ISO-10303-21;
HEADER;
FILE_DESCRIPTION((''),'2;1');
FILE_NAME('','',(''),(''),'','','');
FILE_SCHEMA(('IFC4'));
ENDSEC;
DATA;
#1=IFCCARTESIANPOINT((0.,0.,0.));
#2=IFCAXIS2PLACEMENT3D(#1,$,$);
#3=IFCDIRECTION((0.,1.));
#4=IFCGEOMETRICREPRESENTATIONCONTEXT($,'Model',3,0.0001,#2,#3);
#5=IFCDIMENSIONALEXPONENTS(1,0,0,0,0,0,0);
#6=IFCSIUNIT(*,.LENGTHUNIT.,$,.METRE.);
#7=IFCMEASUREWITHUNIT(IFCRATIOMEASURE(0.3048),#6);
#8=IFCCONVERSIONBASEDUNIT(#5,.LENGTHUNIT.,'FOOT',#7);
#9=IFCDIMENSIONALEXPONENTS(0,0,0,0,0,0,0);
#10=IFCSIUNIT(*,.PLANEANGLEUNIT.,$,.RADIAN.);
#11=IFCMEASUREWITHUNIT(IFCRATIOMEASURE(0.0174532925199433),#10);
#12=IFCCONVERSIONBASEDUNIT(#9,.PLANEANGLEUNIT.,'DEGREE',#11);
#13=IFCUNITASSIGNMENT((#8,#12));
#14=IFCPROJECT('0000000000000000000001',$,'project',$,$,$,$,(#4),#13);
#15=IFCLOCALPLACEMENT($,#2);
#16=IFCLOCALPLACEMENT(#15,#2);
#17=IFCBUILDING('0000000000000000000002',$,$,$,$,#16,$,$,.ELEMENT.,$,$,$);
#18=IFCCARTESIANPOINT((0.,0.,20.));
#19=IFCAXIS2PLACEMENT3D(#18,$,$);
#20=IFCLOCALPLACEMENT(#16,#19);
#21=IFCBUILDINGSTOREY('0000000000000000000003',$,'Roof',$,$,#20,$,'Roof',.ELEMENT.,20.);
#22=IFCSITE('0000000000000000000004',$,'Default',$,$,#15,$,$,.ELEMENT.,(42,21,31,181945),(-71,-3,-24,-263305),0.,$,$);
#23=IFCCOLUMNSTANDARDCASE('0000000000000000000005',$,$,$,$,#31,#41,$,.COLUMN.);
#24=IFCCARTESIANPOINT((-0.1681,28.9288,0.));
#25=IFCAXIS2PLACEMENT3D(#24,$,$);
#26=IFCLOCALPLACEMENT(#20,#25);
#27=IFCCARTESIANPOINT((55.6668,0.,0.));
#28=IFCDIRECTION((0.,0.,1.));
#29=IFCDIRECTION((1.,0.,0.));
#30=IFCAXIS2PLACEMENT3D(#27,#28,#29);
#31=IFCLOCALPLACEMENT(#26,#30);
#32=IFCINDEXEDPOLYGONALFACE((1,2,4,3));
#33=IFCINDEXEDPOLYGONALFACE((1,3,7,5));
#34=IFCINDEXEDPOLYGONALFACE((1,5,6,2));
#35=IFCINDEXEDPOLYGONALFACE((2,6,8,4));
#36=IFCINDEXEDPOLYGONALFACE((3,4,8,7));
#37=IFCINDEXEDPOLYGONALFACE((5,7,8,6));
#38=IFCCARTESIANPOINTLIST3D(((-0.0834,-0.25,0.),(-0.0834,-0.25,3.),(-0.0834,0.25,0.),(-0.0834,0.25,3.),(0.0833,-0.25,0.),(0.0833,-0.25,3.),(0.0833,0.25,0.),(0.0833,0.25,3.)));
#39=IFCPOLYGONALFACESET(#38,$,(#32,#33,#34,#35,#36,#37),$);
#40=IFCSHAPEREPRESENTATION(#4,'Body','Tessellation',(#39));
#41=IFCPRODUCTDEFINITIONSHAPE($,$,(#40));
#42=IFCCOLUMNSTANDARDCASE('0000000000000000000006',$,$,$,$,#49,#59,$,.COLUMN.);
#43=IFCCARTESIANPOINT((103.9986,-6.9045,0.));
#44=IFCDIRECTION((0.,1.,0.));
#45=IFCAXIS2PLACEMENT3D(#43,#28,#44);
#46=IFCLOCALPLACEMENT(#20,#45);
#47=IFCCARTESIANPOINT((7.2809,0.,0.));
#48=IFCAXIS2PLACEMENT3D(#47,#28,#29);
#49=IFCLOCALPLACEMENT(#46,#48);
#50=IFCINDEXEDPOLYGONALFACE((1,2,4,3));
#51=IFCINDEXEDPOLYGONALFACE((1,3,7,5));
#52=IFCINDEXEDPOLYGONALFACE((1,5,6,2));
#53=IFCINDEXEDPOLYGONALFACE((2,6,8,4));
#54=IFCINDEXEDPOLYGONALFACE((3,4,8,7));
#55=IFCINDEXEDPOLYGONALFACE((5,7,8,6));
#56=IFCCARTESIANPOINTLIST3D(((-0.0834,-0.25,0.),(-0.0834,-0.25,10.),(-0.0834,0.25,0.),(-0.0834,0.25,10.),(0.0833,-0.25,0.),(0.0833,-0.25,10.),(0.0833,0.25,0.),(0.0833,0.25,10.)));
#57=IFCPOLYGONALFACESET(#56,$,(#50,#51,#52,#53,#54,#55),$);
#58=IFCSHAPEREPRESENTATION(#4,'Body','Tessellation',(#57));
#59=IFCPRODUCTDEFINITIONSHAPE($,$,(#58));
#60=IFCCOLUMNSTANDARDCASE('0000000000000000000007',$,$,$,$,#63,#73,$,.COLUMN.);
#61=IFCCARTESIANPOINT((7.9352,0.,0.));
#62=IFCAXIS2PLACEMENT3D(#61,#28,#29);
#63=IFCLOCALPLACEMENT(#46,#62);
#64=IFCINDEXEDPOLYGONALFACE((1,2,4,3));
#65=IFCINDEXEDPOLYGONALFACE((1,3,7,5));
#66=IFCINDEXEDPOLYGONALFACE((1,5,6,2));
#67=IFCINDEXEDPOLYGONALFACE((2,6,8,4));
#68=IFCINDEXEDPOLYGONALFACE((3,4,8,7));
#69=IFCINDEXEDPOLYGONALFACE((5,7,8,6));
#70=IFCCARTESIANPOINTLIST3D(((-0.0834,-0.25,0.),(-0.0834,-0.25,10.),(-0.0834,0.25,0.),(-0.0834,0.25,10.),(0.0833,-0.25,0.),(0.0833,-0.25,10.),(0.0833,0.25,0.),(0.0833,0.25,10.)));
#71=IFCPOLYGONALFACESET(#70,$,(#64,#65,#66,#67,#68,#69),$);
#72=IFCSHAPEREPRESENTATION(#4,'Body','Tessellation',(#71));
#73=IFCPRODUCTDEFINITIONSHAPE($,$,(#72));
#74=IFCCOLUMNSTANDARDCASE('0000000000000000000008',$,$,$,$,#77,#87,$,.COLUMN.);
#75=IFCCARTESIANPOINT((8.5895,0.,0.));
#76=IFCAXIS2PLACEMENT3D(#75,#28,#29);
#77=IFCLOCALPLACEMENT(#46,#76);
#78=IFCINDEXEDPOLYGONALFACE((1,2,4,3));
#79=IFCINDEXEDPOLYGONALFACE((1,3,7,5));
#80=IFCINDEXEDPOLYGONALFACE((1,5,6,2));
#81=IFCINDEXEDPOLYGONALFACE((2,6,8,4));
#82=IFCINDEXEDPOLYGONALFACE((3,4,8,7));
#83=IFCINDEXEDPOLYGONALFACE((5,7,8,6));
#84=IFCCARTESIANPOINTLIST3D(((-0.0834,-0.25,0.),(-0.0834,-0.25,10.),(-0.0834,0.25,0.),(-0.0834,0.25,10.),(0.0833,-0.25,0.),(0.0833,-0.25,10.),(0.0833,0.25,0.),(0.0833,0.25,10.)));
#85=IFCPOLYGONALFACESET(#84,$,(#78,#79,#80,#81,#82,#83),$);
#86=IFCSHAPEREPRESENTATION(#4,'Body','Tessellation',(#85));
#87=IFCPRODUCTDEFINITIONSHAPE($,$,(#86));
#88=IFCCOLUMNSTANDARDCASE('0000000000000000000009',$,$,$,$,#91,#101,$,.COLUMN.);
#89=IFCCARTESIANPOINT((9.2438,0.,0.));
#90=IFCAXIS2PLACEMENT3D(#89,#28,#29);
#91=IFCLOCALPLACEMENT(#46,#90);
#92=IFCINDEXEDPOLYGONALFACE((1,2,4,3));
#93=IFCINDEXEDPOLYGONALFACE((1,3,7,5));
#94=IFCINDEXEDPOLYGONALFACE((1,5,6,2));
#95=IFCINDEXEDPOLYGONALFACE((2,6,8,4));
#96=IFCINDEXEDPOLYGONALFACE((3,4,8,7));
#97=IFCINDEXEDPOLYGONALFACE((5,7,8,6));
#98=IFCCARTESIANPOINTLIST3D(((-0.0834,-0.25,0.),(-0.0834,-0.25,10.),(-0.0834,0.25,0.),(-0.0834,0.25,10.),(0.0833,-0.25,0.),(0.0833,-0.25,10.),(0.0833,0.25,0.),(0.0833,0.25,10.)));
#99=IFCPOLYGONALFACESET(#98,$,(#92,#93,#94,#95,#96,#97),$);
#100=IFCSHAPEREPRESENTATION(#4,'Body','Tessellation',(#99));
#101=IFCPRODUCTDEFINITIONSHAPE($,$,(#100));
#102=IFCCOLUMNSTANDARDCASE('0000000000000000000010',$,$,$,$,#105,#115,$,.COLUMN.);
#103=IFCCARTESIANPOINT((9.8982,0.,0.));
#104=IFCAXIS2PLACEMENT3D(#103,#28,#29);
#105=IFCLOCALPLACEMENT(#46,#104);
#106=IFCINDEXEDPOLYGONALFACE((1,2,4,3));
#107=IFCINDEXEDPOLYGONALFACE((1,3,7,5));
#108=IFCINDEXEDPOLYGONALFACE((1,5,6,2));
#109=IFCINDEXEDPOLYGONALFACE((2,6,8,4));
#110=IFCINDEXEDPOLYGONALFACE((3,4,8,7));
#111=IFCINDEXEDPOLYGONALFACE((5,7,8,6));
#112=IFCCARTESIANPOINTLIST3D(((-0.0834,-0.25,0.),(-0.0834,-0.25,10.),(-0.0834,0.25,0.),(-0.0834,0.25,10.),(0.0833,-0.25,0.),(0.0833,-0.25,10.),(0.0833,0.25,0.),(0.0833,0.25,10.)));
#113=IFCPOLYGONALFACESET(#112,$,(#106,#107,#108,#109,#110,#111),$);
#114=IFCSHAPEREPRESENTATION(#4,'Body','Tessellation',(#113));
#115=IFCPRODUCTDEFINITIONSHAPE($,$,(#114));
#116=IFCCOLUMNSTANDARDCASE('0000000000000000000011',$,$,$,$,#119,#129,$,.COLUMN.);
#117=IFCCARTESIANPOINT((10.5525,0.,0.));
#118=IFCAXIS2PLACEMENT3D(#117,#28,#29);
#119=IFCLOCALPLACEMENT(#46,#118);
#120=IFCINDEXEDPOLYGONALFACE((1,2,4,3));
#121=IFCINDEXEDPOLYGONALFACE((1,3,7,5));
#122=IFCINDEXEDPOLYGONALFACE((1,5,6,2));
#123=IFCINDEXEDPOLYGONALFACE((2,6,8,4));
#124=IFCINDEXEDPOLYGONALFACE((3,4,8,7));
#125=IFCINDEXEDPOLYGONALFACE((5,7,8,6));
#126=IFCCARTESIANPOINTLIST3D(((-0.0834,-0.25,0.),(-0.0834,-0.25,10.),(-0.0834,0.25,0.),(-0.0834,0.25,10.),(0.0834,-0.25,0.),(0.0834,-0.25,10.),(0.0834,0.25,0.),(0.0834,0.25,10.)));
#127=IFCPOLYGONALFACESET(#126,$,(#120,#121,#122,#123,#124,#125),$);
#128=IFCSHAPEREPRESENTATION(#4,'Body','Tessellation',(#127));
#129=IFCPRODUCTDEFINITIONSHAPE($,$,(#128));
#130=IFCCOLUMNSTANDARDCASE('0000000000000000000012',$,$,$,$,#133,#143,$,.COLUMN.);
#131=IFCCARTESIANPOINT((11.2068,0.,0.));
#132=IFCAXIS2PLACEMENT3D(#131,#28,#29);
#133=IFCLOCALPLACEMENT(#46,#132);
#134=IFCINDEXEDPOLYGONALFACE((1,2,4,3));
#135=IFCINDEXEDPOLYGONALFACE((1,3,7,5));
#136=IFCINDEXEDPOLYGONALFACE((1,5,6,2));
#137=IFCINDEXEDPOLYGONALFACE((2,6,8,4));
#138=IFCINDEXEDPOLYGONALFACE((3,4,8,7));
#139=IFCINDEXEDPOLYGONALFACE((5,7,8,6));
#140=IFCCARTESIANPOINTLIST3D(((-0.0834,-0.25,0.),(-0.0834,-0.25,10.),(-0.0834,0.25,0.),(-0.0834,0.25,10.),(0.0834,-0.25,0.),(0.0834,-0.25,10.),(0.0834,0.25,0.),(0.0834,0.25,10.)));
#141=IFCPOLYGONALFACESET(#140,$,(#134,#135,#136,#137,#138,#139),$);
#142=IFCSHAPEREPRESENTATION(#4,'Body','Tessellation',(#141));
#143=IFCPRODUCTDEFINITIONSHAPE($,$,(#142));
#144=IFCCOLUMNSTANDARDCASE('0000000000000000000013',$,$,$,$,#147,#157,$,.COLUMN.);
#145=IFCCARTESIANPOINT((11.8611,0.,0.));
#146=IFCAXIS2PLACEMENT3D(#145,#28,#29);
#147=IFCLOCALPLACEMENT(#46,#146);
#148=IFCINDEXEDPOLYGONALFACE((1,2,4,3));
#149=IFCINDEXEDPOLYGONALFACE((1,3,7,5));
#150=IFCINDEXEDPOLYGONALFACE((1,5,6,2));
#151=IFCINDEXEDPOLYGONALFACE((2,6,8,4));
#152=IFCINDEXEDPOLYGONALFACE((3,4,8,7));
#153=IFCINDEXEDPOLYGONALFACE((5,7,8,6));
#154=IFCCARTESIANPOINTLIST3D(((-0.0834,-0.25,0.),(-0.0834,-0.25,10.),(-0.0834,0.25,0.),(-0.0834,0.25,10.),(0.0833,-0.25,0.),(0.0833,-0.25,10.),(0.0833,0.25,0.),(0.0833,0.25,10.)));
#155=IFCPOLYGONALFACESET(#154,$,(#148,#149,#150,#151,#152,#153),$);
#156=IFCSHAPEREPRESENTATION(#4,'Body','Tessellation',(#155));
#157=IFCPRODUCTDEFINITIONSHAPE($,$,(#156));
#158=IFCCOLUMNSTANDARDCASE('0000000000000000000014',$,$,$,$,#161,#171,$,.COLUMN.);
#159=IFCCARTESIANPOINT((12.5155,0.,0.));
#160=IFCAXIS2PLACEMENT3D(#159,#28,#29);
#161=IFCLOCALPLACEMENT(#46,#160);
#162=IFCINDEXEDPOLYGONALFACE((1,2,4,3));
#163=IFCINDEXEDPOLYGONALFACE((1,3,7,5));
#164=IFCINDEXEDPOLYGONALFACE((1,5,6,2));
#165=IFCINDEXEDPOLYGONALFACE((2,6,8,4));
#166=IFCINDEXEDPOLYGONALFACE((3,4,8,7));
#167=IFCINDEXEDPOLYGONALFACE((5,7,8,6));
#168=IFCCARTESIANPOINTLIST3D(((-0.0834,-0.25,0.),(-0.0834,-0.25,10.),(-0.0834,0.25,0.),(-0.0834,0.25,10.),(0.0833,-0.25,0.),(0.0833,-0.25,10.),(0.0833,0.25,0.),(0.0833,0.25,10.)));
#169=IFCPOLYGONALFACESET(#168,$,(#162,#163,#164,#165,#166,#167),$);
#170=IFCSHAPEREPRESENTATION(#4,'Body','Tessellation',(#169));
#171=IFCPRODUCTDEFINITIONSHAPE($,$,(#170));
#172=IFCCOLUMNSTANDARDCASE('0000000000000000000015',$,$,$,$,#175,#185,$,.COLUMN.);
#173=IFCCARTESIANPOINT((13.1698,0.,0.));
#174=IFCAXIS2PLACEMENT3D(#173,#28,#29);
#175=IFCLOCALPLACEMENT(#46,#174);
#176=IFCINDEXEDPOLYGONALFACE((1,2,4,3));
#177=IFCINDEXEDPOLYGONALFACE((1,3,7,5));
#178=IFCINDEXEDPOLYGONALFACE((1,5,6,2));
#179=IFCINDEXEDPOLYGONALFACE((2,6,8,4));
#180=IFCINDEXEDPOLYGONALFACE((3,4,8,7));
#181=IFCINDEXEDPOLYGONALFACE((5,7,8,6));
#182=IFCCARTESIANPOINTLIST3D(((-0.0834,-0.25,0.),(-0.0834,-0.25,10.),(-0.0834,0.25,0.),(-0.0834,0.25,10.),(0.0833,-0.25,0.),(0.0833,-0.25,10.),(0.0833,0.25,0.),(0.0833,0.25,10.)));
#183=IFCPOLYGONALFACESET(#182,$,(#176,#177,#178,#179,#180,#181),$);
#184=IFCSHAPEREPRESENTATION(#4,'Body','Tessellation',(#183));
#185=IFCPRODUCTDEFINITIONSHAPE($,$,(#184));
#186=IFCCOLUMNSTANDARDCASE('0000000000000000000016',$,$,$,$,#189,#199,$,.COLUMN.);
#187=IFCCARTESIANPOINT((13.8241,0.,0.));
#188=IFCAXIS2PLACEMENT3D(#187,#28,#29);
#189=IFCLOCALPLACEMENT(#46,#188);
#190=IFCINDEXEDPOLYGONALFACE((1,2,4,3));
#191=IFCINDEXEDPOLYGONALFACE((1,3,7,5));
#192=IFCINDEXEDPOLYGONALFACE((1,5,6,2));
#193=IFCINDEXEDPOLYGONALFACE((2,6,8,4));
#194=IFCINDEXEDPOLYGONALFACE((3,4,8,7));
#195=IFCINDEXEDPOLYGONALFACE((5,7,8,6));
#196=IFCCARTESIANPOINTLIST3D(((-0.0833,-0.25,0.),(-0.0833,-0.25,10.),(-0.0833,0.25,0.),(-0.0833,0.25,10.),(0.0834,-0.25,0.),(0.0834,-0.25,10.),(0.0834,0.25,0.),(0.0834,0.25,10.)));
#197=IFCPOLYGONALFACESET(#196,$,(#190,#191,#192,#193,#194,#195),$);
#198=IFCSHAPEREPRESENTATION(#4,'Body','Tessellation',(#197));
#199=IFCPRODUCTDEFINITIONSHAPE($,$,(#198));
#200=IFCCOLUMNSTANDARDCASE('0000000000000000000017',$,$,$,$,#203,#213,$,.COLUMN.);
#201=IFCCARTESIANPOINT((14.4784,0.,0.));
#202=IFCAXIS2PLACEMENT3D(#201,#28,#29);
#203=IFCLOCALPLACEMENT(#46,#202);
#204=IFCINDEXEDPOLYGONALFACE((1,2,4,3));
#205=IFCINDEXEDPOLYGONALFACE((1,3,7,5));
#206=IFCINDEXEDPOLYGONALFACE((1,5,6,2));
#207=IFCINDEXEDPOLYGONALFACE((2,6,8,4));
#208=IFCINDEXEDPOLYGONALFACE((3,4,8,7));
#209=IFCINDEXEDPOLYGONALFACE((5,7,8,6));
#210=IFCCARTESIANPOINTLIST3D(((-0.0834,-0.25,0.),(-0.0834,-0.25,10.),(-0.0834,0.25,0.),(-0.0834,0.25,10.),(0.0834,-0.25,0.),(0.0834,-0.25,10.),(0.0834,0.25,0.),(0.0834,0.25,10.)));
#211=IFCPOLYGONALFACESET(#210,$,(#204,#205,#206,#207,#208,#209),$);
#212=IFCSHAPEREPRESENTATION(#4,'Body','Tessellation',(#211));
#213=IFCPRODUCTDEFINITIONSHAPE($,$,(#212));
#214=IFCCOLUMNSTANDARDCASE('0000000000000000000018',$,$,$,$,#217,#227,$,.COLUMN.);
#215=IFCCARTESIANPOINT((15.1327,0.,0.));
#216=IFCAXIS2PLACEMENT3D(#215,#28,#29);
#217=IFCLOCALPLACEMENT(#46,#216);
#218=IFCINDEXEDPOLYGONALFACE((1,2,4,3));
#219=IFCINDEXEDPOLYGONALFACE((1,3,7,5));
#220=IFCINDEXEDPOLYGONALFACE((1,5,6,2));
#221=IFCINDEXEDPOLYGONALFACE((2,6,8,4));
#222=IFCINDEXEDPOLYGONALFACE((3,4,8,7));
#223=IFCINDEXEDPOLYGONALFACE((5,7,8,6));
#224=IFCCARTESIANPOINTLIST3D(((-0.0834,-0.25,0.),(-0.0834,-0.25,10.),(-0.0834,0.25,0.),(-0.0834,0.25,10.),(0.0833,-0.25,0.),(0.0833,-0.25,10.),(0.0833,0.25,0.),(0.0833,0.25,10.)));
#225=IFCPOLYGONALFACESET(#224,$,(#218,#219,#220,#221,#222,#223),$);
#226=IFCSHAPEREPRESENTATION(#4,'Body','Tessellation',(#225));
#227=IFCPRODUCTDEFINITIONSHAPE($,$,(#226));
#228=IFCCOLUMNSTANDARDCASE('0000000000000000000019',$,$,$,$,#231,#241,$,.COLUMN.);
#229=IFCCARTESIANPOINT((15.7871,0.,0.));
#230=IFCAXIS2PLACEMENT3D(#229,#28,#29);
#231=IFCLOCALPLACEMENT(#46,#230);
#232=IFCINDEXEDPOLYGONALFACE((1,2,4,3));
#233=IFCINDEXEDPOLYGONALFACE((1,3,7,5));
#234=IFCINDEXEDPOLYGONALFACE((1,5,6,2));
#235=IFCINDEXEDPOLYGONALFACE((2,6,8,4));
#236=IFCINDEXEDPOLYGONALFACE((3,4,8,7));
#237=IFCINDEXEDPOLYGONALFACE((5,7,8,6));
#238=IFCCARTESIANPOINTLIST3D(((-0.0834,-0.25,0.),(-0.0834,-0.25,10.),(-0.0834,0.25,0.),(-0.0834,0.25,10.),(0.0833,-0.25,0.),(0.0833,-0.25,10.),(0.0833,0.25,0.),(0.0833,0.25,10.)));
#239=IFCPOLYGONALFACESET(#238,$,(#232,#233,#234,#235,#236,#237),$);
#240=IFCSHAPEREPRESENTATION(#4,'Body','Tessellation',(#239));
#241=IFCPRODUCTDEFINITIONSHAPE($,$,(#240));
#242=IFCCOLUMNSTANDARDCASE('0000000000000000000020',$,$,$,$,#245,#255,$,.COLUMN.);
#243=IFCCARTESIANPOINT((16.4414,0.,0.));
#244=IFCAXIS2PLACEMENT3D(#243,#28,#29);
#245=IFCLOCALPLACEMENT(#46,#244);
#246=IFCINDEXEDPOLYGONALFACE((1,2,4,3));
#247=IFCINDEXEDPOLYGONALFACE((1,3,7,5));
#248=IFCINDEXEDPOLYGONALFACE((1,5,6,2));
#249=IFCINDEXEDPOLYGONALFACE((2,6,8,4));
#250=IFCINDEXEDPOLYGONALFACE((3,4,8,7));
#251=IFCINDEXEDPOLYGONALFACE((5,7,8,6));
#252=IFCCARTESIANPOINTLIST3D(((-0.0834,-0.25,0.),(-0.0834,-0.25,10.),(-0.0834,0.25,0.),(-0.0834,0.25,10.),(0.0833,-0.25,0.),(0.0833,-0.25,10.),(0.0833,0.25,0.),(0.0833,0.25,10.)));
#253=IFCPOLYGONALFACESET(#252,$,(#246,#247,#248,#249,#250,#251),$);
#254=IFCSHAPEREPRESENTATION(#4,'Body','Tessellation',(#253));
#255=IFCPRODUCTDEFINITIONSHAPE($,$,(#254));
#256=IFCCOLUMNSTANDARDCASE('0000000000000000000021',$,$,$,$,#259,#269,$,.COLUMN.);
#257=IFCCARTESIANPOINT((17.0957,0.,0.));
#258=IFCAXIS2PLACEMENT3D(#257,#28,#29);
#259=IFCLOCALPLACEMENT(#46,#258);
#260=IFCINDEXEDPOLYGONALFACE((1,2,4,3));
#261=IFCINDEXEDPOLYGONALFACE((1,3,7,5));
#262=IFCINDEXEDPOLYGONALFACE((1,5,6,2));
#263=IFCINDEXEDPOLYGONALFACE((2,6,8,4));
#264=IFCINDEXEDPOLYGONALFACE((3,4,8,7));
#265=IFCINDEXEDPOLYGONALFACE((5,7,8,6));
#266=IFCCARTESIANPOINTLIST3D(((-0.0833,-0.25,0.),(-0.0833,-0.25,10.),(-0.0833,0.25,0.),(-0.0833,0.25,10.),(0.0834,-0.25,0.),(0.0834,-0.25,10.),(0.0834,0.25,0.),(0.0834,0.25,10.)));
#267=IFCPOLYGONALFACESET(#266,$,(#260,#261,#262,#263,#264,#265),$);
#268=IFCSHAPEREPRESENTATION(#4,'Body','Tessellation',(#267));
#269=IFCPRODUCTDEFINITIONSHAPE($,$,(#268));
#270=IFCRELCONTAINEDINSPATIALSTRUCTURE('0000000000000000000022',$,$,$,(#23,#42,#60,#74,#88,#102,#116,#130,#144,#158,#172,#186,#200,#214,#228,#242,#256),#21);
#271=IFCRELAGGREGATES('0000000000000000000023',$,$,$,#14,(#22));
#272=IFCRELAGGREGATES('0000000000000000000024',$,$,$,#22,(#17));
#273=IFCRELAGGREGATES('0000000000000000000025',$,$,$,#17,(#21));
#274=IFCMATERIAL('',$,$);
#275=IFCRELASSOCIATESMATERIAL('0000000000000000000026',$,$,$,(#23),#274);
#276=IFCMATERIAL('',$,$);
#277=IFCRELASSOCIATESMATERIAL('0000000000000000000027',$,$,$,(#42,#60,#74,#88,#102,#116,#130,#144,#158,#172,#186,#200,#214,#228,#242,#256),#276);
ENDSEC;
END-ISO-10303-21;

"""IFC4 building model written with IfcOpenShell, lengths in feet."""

from ifc_helpers import new_model, entity, si_unit, converted_unit, direction, frame, origin, place, context, project, spatial, rectangle, extrude, material, element, save


model = new_model("IFC4")

# Units and contexts
model_context = context("Model", 3, precision=0.0001, world=origin(), true_north=direction((0.0, 1.0)))
ifc_project = project(units=[converted_unit("LENGTHUNIT", "FOOT", entity("IfcRatioMeasure", 0.3048), si_unit("LENGTHUNIT", "METRE"), dimensions=[1, 0, 0, 0, 0, 0, 0]), converted_unit("PLANEANGLEUNIT", "DEGREE", entity("IfcRatioMeasure", 0.0174532925199433), si_unit("PLANEANGLEUNIT", "RADIAN"), dimensions=[0, 0, 0, 0, 0, 0, 0])], contexts=[model_context])

# Site, building, storey
site_placement = place(None, origin())
site = spatial("IfcSite", under=ifc_project, at=site_placement, Name="Default", CompositionType="ELEMENT", RefLatitude=(42, 21, 31, 181945), RefLongitude=(-71, -3, -24, -263305), RefElevation=0.0)
building_placement = place(site_placement, origin())
building = spatial("IfcBuilding", under=site, at=building_placement, CompositionType="ELEMENT")
storey_placement = place(building_placement, frame((0.0, 0.0, 20.0)))
storey = spatial("IfcBuildingStorey", under=building, at=storey_placement, Name="Roof", LongName="Roof", CompositionType="ELEMENT", Elevation=20.0)

# Columns
ifc_material_1 = material(Name="")
placement_1 = place(storey_placement, frame((-0.1681, 28.9288, 0.0)))
for number, where, z_axis, x_axis in (
    (1, (55.6668, 0.0, 0.0), (0.0, 0.0, 1.0), (1.0, 0.0, 0.0)),
):
    element("IfcColumnStandardCase", number, at=place(placement_1, frame(where, z_axis=z_axis, x_axis=x_axis)), inside=storey, material=ifc_material_1, PredefinedType="COLUMN", context=model_context, shape_type="SweptSolid", body=[
        extrude(rectangle(XDim=0.1667, YDim=0.5), origin(), (0.0, 0.0, 1.0), 3.0),
    ])
ifc_material_2 = material(Name="")
placement_2 = place(storey_placement, frame((103.9986, -6.9045, 0.0), z_axis=(0.0, 0.0, 1.0), x_axis=(0.0, 1.0, 0.0)))
for number, where, z_axis, x_axis in (
    (2, (7.2809, 0.0, 0.0), (0.0, 0.0, 1.0), (1.0, 0.0, 0.0)),
    (3, (7.9352, 0.0, 0.0), (0.0, 0.0, 1.0), (1.0, 0.0, 0.0)),
    (4, (8.5895, 0.0, 0.0), (0.0, 0.0, 1.0), (1.0, 0.0, 0.0)),
    (5, (9.2438, 0.0, 0.0), (0.0, 0.0, 1.0), (1.0, 0.0, 0.0)),
    (6, (9.8982, 0.0, 0.0), (0.0, 0.0, 1.0), (1.0, 0.0, 0.0)),
    (7, (10.5525, 0.0, 0.0), (0.0, 0.0, 1.0), (1.0, 0.0, 0.0)),
    (8, (11.2068, 0.0, 0.0), (0.0, 0.0, 1.0), (1.0, 0.0, 0.0)),
    (9, (11.8611, 0.0, 0.0), (0.0, 0.0, 1.0), (1.0, 0.0, 0.0)),
    (10, (12.5155, 0.0, 0.0), (0.0, 0.0, 1.0), (1.0, 0.0, 0.0)),
    (11, (13.1698, 0.0, 0.0), (0.0, 0.0, 1.0), (1.0, 0.0, 0.0)),
    (12, (13.8241, 0.0, 0.0), (0.0, 0.0, 1.0), (1.0, 0.0, 0.0)),
    (13, (14.4784, 0.0, 0.0), (0.0, 0.0, 1.0), (1.0, 0.0, 0.0)),
    (14, (15.1327, 0.0, 0.0), (0.0, 0.0, 1.0), (1.0, 0.0, 0.0)),
    (15, (15.7871, 0.0, 0.0), (0.0, 0.0, 1.0), (1.0, 0.0, 0.0)),
    (16, (16.4414, 0.0, 0.0), (0.0, 0.0, 1.0), (1.0, 0.0, 0.0)),
    (17, (17.0957, 0.0, 0.0), (0.0, 0.0, 1.0), (1.0, 0.0, 0.0)),
):
    element("IfcColumnStandardCase", number, at=place(placement_2, frame(where, z_axis=z_axis, x_axis=x_axis)), inside=storey, material=ifc_material_2, PredefinedType="COLUMN", context=model_context, shape_type="SweptSolid", body=[
        extrude(rectangle(XDim=0.1667, YDim=0.5), origin(), (0.0, 0.0, 1.0), 10.0),
    ])

save(model, "model.ifc")
